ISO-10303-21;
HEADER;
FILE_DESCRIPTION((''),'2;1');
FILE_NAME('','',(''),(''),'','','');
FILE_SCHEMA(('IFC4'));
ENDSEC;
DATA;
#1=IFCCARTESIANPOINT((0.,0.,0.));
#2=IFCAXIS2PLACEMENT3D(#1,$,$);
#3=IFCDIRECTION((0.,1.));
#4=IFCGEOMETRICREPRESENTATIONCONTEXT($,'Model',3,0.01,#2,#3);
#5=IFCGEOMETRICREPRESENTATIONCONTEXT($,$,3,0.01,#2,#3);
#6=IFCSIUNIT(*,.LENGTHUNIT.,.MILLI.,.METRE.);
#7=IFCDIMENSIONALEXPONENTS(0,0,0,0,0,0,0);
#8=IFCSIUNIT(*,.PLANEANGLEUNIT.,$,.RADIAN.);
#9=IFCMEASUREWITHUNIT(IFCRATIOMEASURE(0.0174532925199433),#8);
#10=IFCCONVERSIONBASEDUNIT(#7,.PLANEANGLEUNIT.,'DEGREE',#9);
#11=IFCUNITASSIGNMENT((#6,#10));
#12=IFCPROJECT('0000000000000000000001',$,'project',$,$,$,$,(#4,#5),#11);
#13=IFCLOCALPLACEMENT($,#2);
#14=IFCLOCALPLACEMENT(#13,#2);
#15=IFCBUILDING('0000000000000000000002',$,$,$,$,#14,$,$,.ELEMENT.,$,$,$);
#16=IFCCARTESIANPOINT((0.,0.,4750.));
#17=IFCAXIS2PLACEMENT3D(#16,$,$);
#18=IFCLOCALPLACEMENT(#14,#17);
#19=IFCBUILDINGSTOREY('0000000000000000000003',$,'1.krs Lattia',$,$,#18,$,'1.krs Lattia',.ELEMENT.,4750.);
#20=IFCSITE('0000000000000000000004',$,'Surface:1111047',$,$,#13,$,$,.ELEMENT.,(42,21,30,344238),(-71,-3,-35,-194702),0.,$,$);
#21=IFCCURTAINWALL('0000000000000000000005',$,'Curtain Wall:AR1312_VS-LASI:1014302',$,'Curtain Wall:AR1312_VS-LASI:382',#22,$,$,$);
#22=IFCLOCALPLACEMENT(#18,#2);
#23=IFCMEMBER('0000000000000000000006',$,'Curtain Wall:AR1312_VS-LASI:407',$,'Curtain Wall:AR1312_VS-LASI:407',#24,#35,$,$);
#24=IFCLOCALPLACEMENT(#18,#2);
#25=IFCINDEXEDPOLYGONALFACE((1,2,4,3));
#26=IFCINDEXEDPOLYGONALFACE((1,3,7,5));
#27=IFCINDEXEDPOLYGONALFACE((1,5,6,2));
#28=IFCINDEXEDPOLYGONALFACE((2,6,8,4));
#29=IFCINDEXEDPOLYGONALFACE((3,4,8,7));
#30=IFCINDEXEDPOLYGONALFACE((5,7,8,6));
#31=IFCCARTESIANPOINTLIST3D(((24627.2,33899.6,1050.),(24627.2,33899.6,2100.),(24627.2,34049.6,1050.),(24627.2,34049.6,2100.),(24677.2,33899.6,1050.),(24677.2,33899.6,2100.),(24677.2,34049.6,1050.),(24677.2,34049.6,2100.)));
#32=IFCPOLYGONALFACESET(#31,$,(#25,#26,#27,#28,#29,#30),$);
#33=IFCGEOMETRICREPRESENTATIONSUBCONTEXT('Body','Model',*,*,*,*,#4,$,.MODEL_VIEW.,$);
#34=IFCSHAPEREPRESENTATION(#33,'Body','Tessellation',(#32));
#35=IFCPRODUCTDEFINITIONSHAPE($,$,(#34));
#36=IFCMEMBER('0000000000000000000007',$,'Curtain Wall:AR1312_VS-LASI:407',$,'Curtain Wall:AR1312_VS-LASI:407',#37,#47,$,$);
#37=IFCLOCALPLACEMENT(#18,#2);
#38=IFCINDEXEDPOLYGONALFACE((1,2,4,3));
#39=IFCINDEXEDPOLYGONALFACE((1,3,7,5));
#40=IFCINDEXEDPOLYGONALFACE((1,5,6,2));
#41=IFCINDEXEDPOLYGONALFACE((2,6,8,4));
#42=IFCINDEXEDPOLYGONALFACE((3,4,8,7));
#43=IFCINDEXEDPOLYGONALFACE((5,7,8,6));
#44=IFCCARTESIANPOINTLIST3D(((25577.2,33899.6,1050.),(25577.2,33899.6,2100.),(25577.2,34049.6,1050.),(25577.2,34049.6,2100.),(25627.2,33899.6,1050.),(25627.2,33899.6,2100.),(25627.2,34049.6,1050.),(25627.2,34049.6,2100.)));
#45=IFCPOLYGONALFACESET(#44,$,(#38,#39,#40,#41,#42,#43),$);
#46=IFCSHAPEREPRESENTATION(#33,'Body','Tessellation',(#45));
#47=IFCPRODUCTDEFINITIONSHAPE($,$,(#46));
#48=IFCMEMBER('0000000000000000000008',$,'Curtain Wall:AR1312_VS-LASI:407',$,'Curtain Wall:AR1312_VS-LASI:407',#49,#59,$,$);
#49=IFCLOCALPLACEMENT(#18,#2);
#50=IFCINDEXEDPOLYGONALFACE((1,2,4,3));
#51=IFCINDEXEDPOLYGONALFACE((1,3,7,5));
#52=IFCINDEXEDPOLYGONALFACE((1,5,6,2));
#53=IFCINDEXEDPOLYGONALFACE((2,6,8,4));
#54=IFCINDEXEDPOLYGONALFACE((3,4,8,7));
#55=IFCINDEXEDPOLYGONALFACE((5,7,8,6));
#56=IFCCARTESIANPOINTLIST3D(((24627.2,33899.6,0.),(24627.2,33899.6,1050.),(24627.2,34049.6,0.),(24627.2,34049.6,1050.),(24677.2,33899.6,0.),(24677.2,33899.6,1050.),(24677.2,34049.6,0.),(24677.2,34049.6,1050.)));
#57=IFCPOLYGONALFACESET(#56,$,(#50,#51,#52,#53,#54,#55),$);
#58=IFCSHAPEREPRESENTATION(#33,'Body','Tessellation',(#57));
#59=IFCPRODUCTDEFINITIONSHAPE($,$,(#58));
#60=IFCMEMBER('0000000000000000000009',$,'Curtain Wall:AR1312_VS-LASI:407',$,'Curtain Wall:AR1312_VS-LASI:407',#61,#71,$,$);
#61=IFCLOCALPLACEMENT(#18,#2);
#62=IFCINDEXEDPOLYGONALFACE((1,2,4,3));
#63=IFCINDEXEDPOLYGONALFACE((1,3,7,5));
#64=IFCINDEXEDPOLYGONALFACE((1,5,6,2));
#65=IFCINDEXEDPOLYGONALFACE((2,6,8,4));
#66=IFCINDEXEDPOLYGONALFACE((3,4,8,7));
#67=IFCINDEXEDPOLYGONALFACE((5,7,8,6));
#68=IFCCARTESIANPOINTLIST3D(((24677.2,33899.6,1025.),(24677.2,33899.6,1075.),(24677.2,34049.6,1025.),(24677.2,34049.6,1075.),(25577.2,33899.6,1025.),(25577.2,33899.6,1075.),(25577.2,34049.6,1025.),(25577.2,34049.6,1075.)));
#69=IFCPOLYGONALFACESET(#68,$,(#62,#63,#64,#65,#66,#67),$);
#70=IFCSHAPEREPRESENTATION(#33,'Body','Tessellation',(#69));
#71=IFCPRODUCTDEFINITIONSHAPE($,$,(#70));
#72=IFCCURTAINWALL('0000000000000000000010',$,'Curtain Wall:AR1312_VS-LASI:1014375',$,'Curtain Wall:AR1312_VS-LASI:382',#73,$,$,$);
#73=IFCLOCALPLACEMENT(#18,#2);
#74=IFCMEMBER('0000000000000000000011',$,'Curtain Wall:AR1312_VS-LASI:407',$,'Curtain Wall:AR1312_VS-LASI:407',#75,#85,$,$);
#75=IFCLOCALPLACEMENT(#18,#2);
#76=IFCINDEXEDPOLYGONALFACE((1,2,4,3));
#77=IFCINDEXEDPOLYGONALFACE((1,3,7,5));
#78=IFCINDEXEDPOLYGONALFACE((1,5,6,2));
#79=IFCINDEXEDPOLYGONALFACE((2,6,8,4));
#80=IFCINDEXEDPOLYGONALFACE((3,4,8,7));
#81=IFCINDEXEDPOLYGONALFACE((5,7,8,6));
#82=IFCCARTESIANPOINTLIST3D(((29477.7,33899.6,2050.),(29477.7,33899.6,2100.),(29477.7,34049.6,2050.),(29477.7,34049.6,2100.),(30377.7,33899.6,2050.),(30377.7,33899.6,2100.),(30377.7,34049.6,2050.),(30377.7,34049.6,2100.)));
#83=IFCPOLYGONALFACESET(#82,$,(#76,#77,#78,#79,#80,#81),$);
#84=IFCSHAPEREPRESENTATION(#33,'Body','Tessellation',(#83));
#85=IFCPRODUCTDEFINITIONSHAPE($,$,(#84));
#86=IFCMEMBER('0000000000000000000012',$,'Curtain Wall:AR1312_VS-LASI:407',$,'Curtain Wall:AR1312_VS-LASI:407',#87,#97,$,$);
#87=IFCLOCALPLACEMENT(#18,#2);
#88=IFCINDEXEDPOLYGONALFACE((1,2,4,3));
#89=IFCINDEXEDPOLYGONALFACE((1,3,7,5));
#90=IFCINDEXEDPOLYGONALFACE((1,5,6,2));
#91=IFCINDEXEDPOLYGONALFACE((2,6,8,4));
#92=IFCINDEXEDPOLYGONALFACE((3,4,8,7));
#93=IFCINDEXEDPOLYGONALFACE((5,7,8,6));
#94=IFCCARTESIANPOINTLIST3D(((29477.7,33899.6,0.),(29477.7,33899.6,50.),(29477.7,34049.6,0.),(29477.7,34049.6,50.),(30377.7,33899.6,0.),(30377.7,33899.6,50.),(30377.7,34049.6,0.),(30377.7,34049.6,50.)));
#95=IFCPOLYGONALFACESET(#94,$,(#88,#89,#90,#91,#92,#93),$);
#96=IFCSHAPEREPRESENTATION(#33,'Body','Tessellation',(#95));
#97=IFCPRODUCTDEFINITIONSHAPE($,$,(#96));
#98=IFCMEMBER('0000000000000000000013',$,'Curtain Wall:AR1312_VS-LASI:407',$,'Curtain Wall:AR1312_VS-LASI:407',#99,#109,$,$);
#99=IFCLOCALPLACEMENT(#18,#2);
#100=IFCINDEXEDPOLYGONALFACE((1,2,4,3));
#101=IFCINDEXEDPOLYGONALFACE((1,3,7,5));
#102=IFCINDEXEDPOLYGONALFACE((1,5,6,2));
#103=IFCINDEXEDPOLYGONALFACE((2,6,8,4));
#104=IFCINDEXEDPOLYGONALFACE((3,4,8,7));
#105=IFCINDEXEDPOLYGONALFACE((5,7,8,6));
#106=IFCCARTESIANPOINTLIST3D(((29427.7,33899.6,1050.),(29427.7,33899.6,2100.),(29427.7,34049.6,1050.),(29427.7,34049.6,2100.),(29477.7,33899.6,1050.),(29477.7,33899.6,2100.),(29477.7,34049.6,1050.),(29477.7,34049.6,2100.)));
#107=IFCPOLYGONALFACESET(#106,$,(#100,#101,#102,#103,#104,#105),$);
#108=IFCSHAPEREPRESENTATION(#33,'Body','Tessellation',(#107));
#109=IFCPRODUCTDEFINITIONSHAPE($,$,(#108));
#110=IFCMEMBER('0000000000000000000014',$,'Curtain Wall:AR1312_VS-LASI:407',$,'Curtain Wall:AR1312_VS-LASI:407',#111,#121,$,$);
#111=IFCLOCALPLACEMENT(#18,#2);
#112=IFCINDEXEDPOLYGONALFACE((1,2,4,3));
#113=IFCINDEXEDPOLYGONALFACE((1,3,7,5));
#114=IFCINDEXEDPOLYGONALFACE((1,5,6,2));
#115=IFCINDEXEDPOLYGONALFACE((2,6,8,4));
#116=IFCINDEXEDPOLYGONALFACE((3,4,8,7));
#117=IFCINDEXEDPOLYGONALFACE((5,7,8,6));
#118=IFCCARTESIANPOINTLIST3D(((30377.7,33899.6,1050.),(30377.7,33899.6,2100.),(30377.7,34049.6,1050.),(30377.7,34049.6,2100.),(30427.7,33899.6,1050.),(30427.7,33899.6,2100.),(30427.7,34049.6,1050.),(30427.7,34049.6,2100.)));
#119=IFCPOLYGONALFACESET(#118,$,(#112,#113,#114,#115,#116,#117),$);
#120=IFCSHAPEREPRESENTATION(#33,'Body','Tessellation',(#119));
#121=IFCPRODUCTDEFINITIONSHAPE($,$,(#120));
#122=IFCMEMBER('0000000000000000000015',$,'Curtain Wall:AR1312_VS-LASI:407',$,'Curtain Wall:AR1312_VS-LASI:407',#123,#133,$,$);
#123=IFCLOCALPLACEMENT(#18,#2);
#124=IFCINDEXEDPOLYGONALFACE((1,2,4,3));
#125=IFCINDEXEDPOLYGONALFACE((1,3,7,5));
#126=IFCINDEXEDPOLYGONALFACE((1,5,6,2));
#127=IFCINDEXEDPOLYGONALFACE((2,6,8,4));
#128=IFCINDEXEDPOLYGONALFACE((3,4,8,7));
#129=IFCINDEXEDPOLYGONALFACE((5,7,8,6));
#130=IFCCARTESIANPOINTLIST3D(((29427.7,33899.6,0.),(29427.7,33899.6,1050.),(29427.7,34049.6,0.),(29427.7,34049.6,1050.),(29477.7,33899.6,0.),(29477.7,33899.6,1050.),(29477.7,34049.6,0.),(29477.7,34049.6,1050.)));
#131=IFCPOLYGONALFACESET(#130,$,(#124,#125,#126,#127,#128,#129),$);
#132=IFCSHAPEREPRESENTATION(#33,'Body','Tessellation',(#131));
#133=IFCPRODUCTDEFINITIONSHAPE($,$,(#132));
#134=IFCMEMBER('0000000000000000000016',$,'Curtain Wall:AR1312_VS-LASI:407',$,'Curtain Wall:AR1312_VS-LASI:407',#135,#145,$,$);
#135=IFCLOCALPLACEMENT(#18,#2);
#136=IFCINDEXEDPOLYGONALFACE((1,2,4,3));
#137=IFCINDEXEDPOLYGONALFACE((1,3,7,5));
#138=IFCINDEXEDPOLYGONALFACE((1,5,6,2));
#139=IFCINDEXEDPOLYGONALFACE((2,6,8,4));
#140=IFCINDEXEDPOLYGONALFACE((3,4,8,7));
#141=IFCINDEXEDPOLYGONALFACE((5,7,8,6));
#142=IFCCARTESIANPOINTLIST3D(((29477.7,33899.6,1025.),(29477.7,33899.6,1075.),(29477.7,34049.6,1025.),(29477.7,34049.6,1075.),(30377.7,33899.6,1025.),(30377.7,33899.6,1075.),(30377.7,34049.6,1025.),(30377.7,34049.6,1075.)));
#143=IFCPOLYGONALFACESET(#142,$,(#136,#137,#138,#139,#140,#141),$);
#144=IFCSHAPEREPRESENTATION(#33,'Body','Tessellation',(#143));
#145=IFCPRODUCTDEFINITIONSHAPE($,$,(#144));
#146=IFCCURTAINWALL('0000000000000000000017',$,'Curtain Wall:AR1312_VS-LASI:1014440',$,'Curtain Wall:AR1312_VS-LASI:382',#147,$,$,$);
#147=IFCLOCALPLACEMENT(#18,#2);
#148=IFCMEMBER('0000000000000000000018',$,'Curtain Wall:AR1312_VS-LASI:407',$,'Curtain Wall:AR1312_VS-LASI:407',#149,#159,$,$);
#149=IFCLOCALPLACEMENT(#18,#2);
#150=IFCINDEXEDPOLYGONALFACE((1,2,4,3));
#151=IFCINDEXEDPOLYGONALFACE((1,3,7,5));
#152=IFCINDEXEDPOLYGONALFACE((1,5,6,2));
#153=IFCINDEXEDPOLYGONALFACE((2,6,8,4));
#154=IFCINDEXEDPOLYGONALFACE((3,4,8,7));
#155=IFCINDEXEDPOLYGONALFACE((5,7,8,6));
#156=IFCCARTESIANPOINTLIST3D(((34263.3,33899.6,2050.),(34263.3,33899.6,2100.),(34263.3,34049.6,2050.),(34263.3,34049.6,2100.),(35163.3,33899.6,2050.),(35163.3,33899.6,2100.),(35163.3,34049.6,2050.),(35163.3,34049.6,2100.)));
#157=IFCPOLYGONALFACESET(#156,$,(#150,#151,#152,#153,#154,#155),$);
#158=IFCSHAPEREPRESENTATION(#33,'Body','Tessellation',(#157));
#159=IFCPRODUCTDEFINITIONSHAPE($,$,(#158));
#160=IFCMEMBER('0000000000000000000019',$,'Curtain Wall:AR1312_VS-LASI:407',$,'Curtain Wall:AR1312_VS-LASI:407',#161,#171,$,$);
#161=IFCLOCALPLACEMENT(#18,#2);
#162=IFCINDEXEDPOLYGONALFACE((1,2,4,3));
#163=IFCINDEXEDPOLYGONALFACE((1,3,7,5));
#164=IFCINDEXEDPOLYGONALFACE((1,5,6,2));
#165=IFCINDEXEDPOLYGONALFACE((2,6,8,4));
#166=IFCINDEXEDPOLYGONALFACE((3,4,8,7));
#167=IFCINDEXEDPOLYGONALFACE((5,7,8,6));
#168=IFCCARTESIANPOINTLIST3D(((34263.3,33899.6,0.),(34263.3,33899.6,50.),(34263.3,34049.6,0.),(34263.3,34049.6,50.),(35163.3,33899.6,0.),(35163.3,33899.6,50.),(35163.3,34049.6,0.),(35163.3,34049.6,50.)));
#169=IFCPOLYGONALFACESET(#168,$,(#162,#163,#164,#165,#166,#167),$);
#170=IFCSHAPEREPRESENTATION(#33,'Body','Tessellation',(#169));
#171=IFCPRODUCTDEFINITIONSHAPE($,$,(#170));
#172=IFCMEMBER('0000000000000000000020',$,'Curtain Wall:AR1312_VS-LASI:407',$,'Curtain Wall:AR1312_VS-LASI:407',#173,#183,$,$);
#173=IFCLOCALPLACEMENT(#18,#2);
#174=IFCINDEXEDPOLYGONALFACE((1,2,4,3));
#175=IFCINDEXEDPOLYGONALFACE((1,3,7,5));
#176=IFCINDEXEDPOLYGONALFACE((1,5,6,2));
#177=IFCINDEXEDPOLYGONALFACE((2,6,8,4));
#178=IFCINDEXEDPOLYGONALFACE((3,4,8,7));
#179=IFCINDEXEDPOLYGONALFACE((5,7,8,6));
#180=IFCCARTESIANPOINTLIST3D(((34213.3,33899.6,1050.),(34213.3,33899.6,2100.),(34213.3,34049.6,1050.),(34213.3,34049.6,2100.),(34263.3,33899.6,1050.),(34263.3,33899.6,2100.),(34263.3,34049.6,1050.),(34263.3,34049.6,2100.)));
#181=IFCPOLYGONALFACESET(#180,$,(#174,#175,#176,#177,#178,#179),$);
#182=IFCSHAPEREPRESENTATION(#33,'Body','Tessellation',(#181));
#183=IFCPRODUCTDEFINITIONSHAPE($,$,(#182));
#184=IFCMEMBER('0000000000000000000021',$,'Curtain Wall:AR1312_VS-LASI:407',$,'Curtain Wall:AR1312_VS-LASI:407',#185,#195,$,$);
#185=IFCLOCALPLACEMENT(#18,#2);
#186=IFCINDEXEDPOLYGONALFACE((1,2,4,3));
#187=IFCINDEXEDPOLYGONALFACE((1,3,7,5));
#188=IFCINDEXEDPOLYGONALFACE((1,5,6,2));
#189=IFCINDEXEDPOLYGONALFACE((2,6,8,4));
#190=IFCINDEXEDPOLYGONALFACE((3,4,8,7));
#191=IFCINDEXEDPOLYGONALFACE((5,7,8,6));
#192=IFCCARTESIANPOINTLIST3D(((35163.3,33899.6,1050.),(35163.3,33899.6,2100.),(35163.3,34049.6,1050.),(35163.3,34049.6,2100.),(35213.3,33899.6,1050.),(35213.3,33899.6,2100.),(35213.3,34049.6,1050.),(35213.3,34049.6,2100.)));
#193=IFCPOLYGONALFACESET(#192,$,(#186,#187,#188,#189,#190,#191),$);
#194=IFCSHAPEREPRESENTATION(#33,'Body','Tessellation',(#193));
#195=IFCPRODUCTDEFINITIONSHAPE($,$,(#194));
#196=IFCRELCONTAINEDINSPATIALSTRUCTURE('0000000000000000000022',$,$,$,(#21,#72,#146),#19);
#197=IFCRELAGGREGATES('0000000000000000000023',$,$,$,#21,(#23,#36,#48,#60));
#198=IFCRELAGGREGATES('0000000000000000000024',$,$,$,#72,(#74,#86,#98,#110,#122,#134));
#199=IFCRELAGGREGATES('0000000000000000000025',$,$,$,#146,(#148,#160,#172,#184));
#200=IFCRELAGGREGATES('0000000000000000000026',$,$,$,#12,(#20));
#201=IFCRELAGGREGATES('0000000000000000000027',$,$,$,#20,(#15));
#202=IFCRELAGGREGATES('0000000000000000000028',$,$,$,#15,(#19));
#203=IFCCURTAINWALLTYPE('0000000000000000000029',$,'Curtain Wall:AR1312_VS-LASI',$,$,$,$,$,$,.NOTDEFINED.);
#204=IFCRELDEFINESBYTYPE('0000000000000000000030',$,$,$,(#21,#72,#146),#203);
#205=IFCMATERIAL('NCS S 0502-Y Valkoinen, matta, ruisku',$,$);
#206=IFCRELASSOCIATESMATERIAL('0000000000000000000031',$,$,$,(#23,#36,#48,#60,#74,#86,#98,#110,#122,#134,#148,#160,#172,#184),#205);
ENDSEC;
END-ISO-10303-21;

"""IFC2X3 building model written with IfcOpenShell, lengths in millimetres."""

from ifc_helpers import new_model, entity, si_unit, converted_unit, direction, frame, frame_2d, origin, place, context, subcontext, project, spatial, rectangle, extrude, material, type_object, element, aggregate, save


model = new_model("IFC2X3")

# Units and contexts
model_context = context("Model", 3, precision=0.01, world=origin(), true_north=direction((0.0, 1.0)))
context_of_model = context(None, 3, precision=0.01, world=origin(), true_north=direction((0.0, 1.0)))
body_context = subcontext(model_context, "Body", "Model", "MODEL_VIEW")
ifc_project = project(units=[si_unit("LENGTHUNIT", "METRE", prefix="MILLI"), converted_unit("PLANEANGLEUNIT", "DEGREE", entity("IfcRatioMeasure", 0.0174532925199433), si_unit("PLANEANGLEUNIT", "RADIAN"), dimensions=[0, 0, 0, 0, 0, 0, 0])], contexts=[model_context, context_of_model])

# Site, building, storey
site_placement = place(None, origin())
site = spatial("IfcSite", under=ifc_project, at=site_placement, Name="Surface:1111047", CompositionType="ELEMENT", RefLatitude=(42, 21, 30, 344238), RefLongitude=(-71, -3, -35, -194702), RefElevation=0.0)
building_placement = place(site_placement, origin())
building = spatial("IfcBuilding", under=site, at=building_placement, CompositionType="ELEMENT")
storey_placement = place(building_placement, frame((0.0, 0.0, 4750.0)))
storey = spatial("IfcBuildingStorey", under=building, at=storey_placement, Name="1.krs Lattia", LongName="1.krs Lattia", CompositionType="ELEMENT", Elevation=4750.0)

# Curtain walls, members
curtain_wall_type = type_object("IfcCurtainWallType", Name="Curtain Wall:AR1312_VS-LASI", PredefinedType="NOTDEFINED")
curtain_wall_1_placement = place(storey_placement, frame((0.0, 0.0, -4750.0)))
curtain_wall_1 = element("IfcCurtainWall", 1, at=curtain_wall_1_placement, inside=storey, type_object=curtain_wall_type, Name="Curtain Wall:AR1312_VS-LASI:1014302", ObjectType="Curtain Wall:AR1312_VS-LASI:382")
ifc_material = material(Name="NCS S 0502-Y Valkoinen, matta, ruisku")
member_1_placement = place(curtain_wall_1_placement, frame((0.0, 0.0, 4750.0)))
member_1 = element("IfcMember", 2, at=member_1_placement, material=ifc_material, Name="Curtain Wall:AR1312_VS-LASI:407", ObjectType="Curtain Wall:AR1312_VS-LASI:407", context=body_context, shape_type="SweptSolid", body=[
    extrude(rectangle(XDim=50.0, YDim=150.0, at=frame_2d((0.0, 0.0), x_axis=(1.0, 0.0))), frame((24652.2, 33974.6, 2100.0), z_axis=(0.0, 0.0, -1.0), x_axis=(-1.0, 0.0, 0.0)), (0.0, 0.0, 1.0), 1050.0),
])
member_2_placement = place(curtain_wall_1_placement, frame((0.0, 0.0, 4750.0)))
member_2 = element("IfcMember", 3, at=member_2_placement, material=ifc_material, Name="Curtain Wall:AR1312_VS-LASI:407", ObjectType="Curtain Wall:AR1312_VS-LASI:407", context=body_context, shape_type="SweptSolid", body=[
    extrude(rectangle(XDim=50.0, YDim=150.0, at=frame_2d((0.0, 0.0), x_axis=(1.0, 0.0))), frame((25602.2, 33974.6, 1050.0), z_axis=(0.0, 0.0, 1.0), x_axis=(-1.0, 0.0, 0.0)), (0.0, 0.0, 1.0), 1050.0),
])
member_3_placement = place(curtain_wall_1_placement, frame((0.0, 0.0, 4750.0)))
member_3 = element("IfcMember", 4, at=member_3_placement, material=ifc_material, Name="Curtain Wall:AR1312_VS-LASI:407", ObjectType="Curtain Wall:AR1312_VS-LASI:407", context=body_context, shape_type="SweptSolid", body=[
    extrude(rectangle(XDim=50.0, YDim=150.0, at=frame_2d((0.0, 0.0), x_axis=(1.0, 0.0))), frame((24652.2, 33974.6, 1050.0), z_axis=(0.0, 0.0, -1.0), x_axis=(-1.0, 0.0, 0.0)), (0.0, 0.0, 1.0), 1050.0),
])
member_4_placement = place(curtain_wall_1_placement, frame((0.0, 0.0, 4750.0)))
member_4 = element("IfcMember", 5, at=member_4_placement, material=ifc_material, Name="Curtain Wall:AR1312_VS-LASI:407", ObjectType="Curtain Wall:AR1312_VS-LASI:407", context=body_context, shape_type="SweptSolid", body=[
    extrude(rectangle(XDim=50.0, YDim=150.0, at=frame_2d((0.0, 0.0), x_axis=(1.0, 0.0))), frame((25577.2, 33974.6, 1050.0), z_axis=(-1.0, 0.0, 0.0), x_axis=(0.0, 0.0, -1.0)), (0.0, 0.0, 1.0), 900.0),
])
aggregate(curtain_wall_1, [member_1, member_2, member_3, member_4])
curtain_wall_2_placement = place(storey_placement, frame((0.0, 0.0, -4750.0)))
curtain_wall_2 = element("IfcCurtainWall", 6, at=curtain_wall_2_placement, inside=storey, type_object=curtain_wall_type, Name="Curtain Wall:AR1312_VS-LASI:1014375", ObjectType="Curtain Wall:AR1312_VS-LASI:382")
member_5_placement = place(curtain_wall_2_placement, frame((0.0, 0.0, 4750.0)))
member_5 = element("IfcMember", 7, at=member_5_placement, material=ifc_material, Name="Curtain Wall:AR1312_VS-LASI:407", ObjectType="Curtain Wall:AR1312_VS-LASI:407", context=body_context, shape_type="SweptSolid", body=[
    extrude(rectangle(XDim=50.0, YDim=150.0, at=frame_2d((0.0, 0.0), x_axis=(1.0, 0.0))), frame((30377.7, 33974.6, 2075.0), z_axis=(-1.0, 0.0, 0.0), x_axis=(0.0, 0.0, -1.0)), (0.0, 0.0, 1.0), 900.0),
])
member_6_placement = place(curtain_wall_2_placement, frame((0.0, 0.0, 4750.0)))
member_6 = element("IfcMember", 8, at=member_6_placement, material=ifc_material, Name="Curtain Wall:AR1312_VS-LASI:407", ObjectType="Curtain Wall:AR1312_VS-LASI:407", context=body_context, shape_type="SweptSolid", body=[
    extrude(rectangle(XDim=50.0, YDim=150.0, at=frame_2d((0.0, 0.0), x_axis=(1.0, 0.0))), frame((29477.7, 33974.6, 25.0), z_axis=(1.0, 0.0, 0.0), x_axis=(0.0, 0.0, -1.0)), (0.0, 0.0, 1.0), 900.0),
])
member_7_placement = place(curtain_wall_2_placement, frame((0.0, 0.0, 4750.0)))
member_7 = element("IfcMember", 9, at=member_7_placement, material=ifc_material, Name="Curtain Wall:AR1312_VS-LASI:407", ObjectType="Curtain Wall:AR1312_VS-LASI:407", context=body_context, shape_type="SweptSolid", body=[
    extrude(rectangle(XDim=50.0, YDim=150.0, at=frame_2d((0.0, 0.0), x_axis=(1.0, 0.0))), frame((29452.7, 33974.6, 2100.0), z_axis=(0.0, 0.0, -1.0), x_axis=(-1.0, 0.0, 0.0)), (0.0, 0.0, 1.0), 1050.0),
])
member_8_placement = place(curtain_wall_2_placement, frame((0.0, 0.0, 4750.0)))
member_8 = element("IfcMember", 10, at=member_8_placement, material=ifc_material, Name="Curtain Wall:AR1312_VS-LASI:407", ObjectType="Curtain Wall:AR1312_VS-LASI:407", context=body_context, shape_type="SweptSolid", body=[
    extrude(rectangle(XDim=50.0, YDim=150.0, at=frame_2d((0.0, 0.0), x_axis=(1.0, 0.0))), frame((30402.7, 33974.6, 1050.0), z_axis=(0.0, 0.0, 1.0), x_axis=(-1.0, 0.0, 0.0)), (0.0, 0.0, 1.0), 1050.0),
])
member_9_placement = place(curtain_wall_2_placement, frame((0.0, 0.0, 4750.0)))
member_9 = element("IfcMember", 11, at=member_9_placement, material=ifc_material, Name="Curtain Wall:AR1312_VS-LASI:407", ObjectType="Curtain Wall:AR1312_VS-LASI:407", context=body_context, shape_type="SweptSolid", body=[
    extrude(rectangle(XDim=50.0, YDim=150.0, at=frame_2d((0.0, 0.0), x_axis=(1.0, 0.0))), frame((29452.7, 33974.6, 1050.0), z_axis=(0.0, 0.0, -1.0), x_axis=(-1.0, 0.0, 0.0)), (0.0, 0.0, 1.0), 1050.0),
])
member_10_placement = place(curtain_wall_2_placement, frame((0.0, 0.0, 4750.0)))
member_10 = element("IfcMember", 12, at=member_10_placement, material=ifc_material, Name="Curtain Wall:AR1312_VS-LASI:407", ObjectType="Curtain Wall:AR1312_VS-LASI:407", context=body_context, shape_type="SweptSolid", body=[
    extrude(rectangle(XDim=50.0, YDim=150.0, at=frame_2d((0.0, 0.0), x_axis=(1.0, 0.0))), frame((30377.7, 33974.6, 1050.0), z_axis=(-1.0, 0.0, 0.0), x_axis=(0.0, 0.0, -1.0)), (0.0, 0.0, 1.0), 900.0),
])
aggregate(curtain_wall_2, [member_5, member_6, member_7, member_8, member_9, member_10])
curtain_wall_3_placement = place(storey_placement, frame((0.0, 0.0, -4750.0)))
curtain_wall_3 = element("IfcCurtainWall", 13, at=curtain_wall_3_placement, inside=storey, type_object=curtain_wall_type, Name="Curtain Wall:AR1312_VS-LASI:1014440", ObjectType="Curtain Wall:AR1312_VS-LASI:382")
member_11_placement = place(curtain_wall_3_placement, frame((0.0, 0.0, 4750.0)))
member_11 = element("IfcMember", 14, at=member_11_placement, material=ifc_material, Name="Curtain Wall:AR1312_VS-LASI:407", ObjectType="Curtain Wall:AR1312_VS-LASI:407", context=body_context, shape_type="SweptSolid", body=[
    extrude(rectangle(XDim=50.0, YDim=150.0, at=frame_2d((0.0, 0.0), x_axis=(1.0, 0.0))), frame((35163.3, 33974.6, 2075.0), z_axis=(-1.0, 0.0, 0.0), x_axis=(0.0, 0.0, -1.0)), (0.0, 0.0, 1.0), 900.0),
])
member_12_placement = place(curtain_wall_3_placement, frame((0.0, 0.0, 4750.0)))
member_12 = element("IfcMember", 15, at=member_12_placement, material=ifc_material, Name="Curtain Wall:AR1312_VS-LASI:407", ObjectType="Curtain Wall:AR1312_VS-LASI:407", context=body_context, shape_type="SweptSolid", body=[
    extrude(rectangle(XDim=50.0, YDim=150.0, at=frame_2d((0.0, 0.0), x_axis=(1.0, 0.0))), frame((34263.3, 33974.6, 25.0), z_axis=(1.0, 0.0, 0.0), x_axis=(0.0, 0.0, -1.0)), (0.0, 0.0, 1.0), 900.0),
])
member_13_placement = place(curtain_wall_3_placement, frame((0.0, 0.0, 4750.0)))
member_13 = element("IfcMember", 16, at=member_13_placement, material=ifc_material, Name="Curtain Wall:AR1312_VS-LASI:407", ObjectType="Curtain Wall:AR1312_VS-LASI:407", context=body_context, shape_type="SweptSolid", body=[
    extrude(rectangle(XDim=50.0, YDim=150.0, at=frame_2d((0.0, 0.0), x_axis=(1.0, 0.0))), frame((34238.3, 33974.6, 2100.0), z_axis=(0.0, 0.0, -1.0), x_axis=(-1.0, 0.0, 0.0)), (0.0, 0.0, 1.0), 1050.0),
])
member_14_placement = place(curtain_wall_3_placement, frame((0.0, 0.0, 4750.0)))
member_14 = element("IfcMember", 17, at=member_14_placement, material=ifc_material, Name="Curtain Wall:AR1312_VS-LASI:407", ObjectType="Curtain Wall:AR1312_VS-LASI:407", context=body_context, shape_type="SweptSolid", body=[
    extrude(rectangle(XDim=50.0, YDim=150.0, at=frame_2d((0.0, 0.0), x_axis=(1.0, 0.0))), frame((35188.3, 33974.6, 1050.0), z_axis=(0.0, 0.0, 1.0), x_axis=(-1.0, 0.0, 0.0)), (0.0, 0.0, 1.0), 1050.0),
])
aggregate(curtain_wall_3, [member_11, member_12, member_13, member_14])

save(model, "model.ifc")
